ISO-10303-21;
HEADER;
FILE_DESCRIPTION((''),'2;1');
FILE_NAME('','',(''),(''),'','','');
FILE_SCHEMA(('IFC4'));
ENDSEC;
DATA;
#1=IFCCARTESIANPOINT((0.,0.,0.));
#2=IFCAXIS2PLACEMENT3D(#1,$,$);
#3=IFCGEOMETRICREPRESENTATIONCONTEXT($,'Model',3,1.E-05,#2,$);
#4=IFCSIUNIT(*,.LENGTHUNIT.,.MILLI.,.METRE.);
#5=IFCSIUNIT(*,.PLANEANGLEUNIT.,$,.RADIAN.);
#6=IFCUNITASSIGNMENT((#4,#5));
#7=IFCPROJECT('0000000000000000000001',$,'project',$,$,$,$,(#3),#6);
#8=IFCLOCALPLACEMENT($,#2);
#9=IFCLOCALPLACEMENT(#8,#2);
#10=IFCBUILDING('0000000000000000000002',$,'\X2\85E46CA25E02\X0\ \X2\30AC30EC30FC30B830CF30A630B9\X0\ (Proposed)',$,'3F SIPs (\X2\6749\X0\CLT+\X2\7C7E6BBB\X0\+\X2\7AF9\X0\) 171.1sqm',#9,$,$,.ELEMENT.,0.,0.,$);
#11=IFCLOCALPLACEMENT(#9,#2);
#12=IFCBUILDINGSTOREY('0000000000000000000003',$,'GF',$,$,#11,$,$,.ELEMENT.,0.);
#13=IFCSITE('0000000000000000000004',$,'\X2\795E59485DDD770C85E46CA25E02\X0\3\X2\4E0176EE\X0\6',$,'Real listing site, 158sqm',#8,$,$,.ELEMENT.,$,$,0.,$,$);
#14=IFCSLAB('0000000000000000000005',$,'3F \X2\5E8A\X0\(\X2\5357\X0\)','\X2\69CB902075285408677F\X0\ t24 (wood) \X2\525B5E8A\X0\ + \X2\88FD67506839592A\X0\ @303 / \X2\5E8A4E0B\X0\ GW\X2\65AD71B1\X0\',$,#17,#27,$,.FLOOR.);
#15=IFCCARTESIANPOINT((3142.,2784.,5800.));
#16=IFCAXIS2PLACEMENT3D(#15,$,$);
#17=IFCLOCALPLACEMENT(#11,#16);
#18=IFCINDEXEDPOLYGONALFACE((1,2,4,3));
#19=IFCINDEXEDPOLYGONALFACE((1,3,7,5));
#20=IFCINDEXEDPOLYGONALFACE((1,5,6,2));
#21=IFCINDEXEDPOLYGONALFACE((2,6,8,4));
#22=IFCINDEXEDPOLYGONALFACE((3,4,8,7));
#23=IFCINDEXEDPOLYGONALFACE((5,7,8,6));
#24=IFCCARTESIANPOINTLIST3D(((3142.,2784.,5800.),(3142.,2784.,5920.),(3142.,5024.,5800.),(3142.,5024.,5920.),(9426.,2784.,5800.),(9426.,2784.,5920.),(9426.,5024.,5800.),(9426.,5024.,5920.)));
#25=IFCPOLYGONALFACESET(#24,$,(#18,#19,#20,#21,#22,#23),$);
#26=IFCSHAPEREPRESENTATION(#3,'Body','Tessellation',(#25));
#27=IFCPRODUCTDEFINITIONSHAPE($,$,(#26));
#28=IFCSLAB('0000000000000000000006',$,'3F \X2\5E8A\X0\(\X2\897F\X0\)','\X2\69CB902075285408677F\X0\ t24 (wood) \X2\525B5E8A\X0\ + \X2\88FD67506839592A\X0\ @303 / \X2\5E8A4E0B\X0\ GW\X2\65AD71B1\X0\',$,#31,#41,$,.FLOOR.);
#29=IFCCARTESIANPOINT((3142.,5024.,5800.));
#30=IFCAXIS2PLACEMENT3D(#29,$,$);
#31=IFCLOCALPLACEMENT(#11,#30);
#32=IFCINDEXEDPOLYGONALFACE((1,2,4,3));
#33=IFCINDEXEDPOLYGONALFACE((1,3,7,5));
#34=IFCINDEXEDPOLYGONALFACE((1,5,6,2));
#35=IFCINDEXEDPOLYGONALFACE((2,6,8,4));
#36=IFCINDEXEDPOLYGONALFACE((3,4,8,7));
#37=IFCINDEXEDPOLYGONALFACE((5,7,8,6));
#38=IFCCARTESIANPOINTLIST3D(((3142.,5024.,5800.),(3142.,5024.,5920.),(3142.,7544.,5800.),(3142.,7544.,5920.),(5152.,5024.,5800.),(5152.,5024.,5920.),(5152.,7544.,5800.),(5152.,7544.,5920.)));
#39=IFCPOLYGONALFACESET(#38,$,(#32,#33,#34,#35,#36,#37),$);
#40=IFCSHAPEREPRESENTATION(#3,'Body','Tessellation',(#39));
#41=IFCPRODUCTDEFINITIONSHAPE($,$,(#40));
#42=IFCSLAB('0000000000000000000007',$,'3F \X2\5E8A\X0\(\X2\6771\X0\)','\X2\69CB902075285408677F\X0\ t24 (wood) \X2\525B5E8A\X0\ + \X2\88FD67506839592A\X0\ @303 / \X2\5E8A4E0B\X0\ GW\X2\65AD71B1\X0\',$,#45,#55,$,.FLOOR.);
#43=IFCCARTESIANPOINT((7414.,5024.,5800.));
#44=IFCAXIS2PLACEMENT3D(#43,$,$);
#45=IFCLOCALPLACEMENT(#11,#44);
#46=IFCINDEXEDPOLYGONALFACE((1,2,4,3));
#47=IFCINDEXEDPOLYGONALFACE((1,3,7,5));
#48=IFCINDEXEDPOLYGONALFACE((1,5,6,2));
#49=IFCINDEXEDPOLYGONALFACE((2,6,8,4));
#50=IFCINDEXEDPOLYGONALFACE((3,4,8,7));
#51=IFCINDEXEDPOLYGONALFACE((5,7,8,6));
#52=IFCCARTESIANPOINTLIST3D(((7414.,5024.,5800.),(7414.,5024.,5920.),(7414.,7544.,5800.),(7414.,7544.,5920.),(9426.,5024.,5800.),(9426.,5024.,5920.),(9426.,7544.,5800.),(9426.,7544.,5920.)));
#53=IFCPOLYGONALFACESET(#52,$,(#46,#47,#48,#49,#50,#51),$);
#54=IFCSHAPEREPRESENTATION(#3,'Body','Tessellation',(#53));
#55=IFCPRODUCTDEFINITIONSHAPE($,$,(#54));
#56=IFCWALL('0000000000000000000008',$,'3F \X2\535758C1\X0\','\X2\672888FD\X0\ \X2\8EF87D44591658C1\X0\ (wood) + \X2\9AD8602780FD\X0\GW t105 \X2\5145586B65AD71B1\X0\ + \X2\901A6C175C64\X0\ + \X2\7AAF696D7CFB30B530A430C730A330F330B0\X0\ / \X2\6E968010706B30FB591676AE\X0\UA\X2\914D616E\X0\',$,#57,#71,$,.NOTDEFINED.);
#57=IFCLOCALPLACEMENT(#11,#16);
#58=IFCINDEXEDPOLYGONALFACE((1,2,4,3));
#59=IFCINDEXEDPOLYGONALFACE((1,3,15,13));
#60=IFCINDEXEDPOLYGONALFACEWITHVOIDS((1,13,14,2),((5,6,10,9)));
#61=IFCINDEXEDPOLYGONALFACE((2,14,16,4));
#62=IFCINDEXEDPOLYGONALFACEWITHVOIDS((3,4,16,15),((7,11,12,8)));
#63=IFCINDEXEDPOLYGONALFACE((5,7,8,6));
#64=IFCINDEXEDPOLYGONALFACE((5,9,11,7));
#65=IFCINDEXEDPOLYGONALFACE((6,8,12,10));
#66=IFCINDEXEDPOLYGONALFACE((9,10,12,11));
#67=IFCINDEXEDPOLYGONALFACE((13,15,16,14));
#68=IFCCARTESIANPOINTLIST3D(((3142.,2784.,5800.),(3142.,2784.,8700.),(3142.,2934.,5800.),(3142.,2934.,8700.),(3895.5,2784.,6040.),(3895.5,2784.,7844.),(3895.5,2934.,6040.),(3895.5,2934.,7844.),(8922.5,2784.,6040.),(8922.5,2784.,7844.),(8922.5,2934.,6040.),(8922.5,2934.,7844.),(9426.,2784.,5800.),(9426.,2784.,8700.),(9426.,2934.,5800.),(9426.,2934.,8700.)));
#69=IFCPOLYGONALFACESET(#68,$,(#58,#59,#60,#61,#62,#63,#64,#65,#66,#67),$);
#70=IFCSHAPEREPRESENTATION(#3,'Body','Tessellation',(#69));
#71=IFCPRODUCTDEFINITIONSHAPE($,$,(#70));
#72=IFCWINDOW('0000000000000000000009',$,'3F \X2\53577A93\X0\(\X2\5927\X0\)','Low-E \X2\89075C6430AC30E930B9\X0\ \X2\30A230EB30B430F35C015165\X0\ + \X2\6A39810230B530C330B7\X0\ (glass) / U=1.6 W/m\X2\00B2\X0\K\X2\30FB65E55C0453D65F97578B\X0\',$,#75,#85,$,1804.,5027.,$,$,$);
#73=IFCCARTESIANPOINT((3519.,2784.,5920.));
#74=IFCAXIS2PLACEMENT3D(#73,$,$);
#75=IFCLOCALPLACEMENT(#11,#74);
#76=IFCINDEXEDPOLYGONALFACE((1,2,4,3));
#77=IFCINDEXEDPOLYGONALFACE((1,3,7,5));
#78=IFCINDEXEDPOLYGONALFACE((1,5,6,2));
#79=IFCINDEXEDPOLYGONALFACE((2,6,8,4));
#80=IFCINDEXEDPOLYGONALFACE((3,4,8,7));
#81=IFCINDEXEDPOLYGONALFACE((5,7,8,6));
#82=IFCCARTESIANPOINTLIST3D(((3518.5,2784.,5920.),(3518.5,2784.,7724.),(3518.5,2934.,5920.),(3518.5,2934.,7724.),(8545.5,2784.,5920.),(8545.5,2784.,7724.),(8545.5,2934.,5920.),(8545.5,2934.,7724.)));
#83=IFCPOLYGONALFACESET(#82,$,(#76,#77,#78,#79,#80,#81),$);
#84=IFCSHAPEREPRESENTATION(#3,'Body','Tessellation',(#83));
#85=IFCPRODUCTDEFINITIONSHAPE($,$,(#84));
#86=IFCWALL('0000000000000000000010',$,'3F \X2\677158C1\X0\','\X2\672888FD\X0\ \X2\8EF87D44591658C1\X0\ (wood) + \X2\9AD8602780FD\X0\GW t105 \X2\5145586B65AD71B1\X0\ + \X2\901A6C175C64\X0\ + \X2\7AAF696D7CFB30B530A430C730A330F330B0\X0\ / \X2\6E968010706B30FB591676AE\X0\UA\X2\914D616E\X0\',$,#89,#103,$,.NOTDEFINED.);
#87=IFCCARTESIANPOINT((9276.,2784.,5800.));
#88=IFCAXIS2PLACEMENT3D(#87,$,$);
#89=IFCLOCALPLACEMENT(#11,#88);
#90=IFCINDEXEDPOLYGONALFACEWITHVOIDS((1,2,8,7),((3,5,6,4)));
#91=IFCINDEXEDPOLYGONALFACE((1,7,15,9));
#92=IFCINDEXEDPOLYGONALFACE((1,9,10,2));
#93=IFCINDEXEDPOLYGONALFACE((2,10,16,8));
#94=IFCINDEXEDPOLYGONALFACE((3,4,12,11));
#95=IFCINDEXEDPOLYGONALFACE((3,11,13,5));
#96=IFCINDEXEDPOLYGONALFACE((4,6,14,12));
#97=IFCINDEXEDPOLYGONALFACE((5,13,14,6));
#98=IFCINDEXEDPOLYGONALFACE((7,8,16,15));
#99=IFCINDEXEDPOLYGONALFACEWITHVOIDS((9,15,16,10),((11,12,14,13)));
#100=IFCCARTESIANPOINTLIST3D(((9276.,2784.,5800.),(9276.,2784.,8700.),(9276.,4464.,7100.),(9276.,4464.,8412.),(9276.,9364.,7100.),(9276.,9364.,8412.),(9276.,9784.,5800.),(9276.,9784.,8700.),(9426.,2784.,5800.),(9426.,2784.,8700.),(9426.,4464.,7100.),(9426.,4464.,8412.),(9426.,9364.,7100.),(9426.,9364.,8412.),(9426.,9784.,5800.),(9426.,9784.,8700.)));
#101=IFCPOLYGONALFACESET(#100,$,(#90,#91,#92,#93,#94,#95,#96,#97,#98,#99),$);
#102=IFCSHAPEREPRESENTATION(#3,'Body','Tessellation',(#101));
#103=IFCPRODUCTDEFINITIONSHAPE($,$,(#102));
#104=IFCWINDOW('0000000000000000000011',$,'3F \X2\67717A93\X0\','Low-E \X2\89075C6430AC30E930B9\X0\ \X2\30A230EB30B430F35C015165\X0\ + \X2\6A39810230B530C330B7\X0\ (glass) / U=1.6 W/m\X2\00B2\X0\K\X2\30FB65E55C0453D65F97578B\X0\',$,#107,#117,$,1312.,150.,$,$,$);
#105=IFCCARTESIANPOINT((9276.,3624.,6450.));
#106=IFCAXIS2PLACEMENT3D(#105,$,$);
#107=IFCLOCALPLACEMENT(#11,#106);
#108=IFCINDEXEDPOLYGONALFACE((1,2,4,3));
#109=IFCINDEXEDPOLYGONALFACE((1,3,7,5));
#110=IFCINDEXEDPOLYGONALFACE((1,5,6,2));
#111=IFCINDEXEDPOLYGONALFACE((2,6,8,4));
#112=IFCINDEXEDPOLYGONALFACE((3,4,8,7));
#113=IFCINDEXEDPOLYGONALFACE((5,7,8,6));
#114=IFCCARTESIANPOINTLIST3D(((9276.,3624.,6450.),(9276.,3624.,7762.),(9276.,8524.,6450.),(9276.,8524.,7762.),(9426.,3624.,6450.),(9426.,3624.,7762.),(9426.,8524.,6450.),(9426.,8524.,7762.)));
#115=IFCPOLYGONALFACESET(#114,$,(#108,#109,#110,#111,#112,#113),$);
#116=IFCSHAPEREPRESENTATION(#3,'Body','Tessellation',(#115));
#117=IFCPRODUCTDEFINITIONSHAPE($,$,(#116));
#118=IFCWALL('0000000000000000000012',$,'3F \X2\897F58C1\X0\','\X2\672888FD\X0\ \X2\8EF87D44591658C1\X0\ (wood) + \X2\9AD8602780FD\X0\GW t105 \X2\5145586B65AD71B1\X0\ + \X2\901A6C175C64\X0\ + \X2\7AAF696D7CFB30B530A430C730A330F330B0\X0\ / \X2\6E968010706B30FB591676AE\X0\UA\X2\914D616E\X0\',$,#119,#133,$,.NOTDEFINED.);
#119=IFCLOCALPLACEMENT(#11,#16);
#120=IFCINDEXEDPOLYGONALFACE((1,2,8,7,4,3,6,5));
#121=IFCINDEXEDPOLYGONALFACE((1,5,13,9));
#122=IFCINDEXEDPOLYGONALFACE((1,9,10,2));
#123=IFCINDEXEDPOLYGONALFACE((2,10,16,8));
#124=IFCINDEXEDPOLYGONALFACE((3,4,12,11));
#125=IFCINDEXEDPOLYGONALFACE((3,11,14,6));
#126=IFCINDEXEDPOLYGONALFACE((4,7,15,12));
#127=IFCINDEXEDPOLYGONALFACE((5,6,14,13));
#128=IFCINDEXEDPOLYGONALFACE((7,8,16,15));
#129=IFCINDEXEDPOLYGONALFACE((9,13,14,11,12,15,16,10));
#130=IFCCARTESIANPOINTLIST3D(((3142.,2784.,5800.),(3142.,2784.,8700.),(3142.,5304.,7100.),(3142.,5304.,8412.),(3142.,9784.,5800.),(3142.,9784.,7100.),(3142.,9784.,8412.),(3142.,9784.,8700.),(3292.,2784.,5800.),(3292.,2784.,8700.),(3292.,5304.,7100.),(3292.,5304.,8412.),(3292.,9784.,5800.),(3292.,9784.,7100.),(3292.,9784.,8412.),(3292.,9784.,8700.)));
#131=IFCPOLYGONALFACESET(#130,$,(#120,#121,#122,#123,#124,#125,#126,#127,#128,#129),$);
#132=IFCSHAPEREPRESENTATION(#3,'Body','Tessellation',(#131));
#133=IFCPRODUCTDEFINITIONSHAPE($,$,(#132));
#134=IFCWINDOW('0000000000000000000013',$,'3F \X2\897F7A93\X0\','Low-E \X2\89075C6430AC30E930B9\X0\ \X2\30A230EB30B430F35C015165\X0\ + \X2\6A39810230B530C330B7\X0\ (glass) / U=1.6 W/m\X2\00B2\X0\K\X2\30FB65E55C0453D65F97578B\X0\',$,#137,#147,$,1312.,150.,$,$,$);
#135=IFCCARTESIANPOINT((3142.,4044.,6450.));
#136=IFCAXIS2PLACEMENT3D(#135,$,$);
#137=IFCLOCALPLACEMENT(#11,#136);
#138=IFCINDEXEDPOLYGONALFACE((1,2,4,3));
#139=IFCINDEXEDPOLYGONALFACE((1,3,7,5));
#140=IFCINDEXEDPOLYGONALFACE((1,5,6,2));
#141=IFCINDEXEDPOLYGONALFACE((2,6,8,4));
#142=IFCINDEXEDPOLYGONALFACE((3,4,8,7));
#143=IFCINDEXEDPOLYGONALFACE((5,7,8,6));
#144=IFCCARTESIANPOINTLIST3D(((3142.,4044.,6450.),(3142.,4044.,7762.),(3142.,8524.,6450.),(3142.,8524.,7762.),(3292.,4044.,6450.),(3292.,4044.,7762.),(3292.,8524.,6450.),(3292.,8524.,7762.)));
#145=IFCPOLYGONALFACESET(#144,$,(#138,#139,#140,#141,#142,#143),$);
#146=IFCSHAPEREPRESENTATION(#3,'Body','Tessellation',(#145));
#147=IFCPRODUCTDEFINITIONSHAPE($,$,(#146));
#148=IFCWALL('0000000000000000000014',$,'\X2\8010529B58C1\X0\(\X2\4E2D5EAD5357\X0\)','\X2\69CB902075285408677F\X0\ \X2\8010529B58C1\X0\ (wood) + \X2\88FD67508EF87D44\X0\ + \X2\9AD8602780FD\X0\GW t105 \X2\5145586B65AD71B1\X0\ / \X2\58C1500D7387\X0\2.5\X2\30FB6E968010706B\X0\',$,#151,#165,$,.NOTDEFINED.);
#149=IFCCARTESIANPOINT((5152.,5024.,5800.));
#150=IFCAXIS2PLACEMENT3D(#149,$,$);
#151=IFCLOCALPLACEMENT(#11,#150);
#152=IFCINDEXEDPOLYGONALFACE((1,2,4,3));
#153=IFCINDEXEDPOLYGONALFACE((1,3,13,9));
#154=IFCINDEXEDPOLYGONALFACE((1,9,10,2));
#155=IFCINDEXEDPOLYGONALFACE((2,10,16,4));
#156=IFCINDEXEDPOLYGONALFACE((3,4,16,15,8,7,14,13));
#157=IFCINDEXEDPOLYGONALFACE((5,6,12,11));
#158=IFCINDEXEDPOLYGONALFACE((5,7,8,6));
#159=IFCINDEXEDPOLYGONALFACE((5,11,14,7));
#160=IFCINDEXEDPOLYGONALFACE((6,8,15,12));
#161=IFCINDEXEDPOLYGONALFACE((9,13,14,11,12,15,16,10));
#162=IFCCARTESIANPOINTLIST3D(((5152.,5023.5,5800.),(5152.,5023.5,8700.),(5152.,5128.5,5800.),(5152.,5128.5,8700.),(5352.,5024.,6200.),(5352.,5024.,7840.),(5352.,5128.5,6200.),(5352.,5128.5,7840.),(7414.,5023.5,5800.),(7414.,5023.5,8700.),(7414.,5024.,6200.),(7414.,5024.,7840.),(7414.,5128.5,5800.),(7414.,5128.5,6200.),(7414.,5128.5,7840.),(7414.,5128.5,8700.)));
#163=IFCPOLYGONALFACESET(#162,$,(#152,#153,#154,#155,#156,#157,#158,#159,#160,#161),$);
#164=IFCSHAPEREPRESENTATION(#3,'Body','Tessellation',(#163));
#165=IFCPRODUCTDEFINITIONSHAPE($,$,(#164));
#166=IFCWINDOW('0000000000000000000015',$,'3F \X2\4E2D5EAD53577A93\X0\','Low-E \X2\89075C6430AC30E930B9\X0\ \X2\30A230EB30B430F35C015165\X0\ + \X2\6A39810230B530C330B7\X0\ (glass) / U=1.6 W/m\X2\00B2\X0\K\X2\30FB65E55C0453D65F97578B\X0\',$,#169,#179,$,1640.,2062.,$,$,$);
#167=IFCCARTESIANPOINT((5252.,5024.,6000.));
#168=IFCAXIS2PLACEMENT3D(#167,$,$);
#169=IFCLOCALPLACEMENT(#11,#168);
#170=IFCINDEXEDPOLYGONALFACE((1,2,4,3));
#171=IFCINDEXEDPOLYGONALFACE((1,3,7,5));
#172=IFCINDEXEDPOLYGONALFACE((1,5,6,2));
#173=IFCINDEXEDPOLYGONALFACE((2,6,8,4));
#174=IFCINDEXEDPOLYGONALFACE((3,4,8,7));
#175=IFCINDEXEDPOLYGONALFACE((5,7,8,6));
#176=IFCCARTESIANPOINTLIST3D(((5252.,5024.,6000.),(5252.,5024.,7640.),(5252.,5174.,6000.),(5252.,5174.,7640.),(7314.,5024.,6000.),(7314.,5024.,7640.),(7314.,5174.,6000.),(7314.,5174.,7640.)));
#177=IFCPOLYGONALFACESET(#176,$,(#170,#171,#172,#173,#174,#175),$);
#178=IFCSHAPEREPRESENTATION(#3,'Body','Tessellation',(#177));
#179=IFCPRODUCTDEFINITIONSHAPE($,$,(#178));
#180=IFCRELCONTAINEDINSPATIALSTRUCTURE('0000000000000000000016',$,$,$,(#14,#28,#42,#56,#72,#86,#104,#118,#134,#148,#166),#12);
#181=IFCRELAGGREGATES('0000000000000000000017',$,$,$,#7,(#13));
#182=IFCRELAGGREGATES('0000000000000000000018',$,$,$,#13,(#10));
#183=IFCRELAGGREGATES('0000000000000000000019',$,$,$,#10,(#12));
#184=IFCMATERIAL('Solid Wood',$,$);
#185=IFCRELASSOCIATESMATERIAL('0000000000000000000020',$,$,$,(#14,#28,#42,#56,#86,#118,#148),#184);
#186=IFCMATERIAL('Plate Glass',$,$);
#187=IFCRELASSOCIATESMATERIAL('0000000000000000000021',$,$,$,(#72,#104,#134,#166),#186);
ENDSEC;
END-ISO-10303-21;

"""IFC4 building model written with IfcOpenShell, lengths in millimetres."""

from ifc_helpers import new_model, si_unit, frame, frame_2d, origin, place, context, project, spatial, rectangle, extrude, material, element, fill, save


model = new_model("IFC4")

# Units and contexts
model_context = context("Model", 3, precision=1e-05, world=origin())
ifc_project = project(units=[si_unit("LENGTHUNIT", "METRE", prefix="MILLI"), si_unit("PLANEANGLEUNIT", "RADIAN")], contexts=[model_context])

# Site, building, storey
site_placement = place(None, origin())
site = spatial("IfcSite", under=ifc_project, at=site_placement, Name="神奈川県藤沢市3丁目6", ObjectType="Real listing site, 158sqm", CompositionType="ELEMENT", RefElevation=0.0)
building_placement = place(site_placement, origin())
building = spatial("IfcBuilding", under=site, at=building_placement, Name="藤沢市 ガレージハウス (Proposed)", ObjectType="3F SIPs (杉CLT+籾殻+竹) 171.1sqm", CompositionType="ELEMENT", ElevationOfRefHeight=0.0, ElevationOfTerrain=0.0)
storey_placement = place(building_placement, origin())
storey = spatial("IfcBuildingStorey", under=building, at=storey_placement, Name="GF", CompositionType="ELEMENT", Elevation=0.0)

# Slabs
ifc_material_1 = material(Name="Solid Wood")
slab_1_placement = place(storey_placement, frame((3142.0, 2784.0, 5800.0)))
element("IfcSlab", 1, at=slab_1_placement, inside=storey, material=ifc_material_1, Name="3F 床(南)", Description="構造用合板 t24 (wood) 剛床 + 製材根太 @303 / 床下 GW断熱", PredefinedType="FLOOR", context=model_context, shape_type="SweptSolid", body=[
    extrude(rectangle(XDim=6284.0, YDim=2240.0, at=frame_2d((3142.0, 1120.0))), frame((3142.0, 2784.0, 5800.0)), (0.0, 0.0, 1.0), 120.0),
])
slab_2_placement = place(storey_placement, frame((3142.0, 5024.0, 5800.0)))
element("IfcSlab", 2, at=slab_2_placement, inside=storey, material=ifc_material_1, Name="3F 床(西)", Description="構造用合板 t24 (wood) 剛床 + 製材根太 @303 / 床下 GW断熱", PredefinedType="FLOOR", context=model_context, shape_type="SweptSolid", body=[
    extrude(rectangle(XDim=2010.0, YDim=2520.0, at=frame_2d((1005.0, 1260.0))), frame((3142.0, 5024.0, 5800.0)), (0.0, 0.0, 1.0), 120.0),
])
slab_3_placement = place(storey_placement, frame((7414.0, 5024.0, 5800.0)))
element("IfcSlab", 3, at=slab_3_placement, inside=storey, material=ifc_material_1, Name="3F 床(東)", Description="構造用合板 t24 (wood) 剛床 + 製材根太 @303 / 床下 GW断熱", PredefinedType="FLOOR", context=model_context, shape_type="SweptSolid", body=[
    extrude(rectangle(XDim=2012.0, YDim=2520.0, at=frame_2d((1006.0, 1260.0))), frame((7414.0, 5024.0, 5800.0)), (0.0, 0.0, 1.0), 120.0),
])

# Walls, openings, windows
wall_1_placement = place(storey_placement, frame((3142.0, 2784.0, 5800.0)))
wall_1 = element("IfcWall", 4, at=wall_1_placement, inside=storey, material=ifc_material_1, Name="3F 南壁", Description="木製 軸組外壁 (wood) + 高性能GW t105 充填断熱 + 通気層 + 窯業系サイディング / 準耐火・外皮UA配慮", PredefinedType="NOTDEFINED", context=model_context, shape_type="SweptSolid", body=[
    extrude(rectangle(XDim=6284.0, YDim=150.0, at=frame_2d((3142.0, 75.0))), frame((3142.0, 2784.0, 5800.0)), (0.0, 0.0, 1.0), 2900.0),
])
opening_1_placement = place(storey_placement, frame((3519.0, 2784.0, 5920.0)))
opening_1 = element("IfcOpeningElement", 5, at=opening_1_placement, cuts=wall_1, PredefinedType="NOTDEFINED", context=model_context, shape_type="SweptSolid", body=[
    extrude(rectangle(XDim=5027.0, YDim=150.0, at=frame_2d((2513.0, 75.0))), frame((3519.0, 2784.0, 5920.0)), (0.0, 0.0, 1.0), 1804.0),
])
ifc_material_2 = material(Name="Plate Glass")
window_1_placement = place(storey_placement, frame((3519.0, 2784.0, 5920.0)))
window_1 = element("IfcWindow", 6, at=window_1_placement, inside=storey, material=ifc_material_2, Name="3F 南窓(大)", Description="Low-E 複層ガラス アルゴン封入 + 樹脂サッシ (glass) / U=1.6 W/m²K・日射取得型", OverallHeight=1804.0, OverallWidth=5027.0, context=model_context, shape_type="SweptSolid", body=[
    extrude(rectangle(XDim=5027.0, YDim=150.0, at=frame_2d((2513.0, 75.0))), frame((3519.0, 2784.0, 5920.0)), (0.0, 0.0, 1.0), 1804.0),
])
fill(opening_1, window_1)
wall_2_placement = place(storey_placement, frame((9276.0, 2784.0, 5800.0)))
wall_2 = element("IfcWall", 7, at=wall_2_placement, inside=storey, material=ifc_material_1, Name="3F 東壁", Description="木製 軸組外壁 (wood) + 高性能GW t105 充填断熱 + 通気層 + 窯業系サイディング / 準耐火・外皮UA配慮", PredefinedType="NOTDEFINED", context=model_context, shape_type="SweptSolid", body=[
    extrude(rectangle(XDim=150.0, YDim=7000.0, at=frame_2d((75.0, 3500.0))), frame((9276.0, 2784.0, 5800.0)), (0.0, 0.0, 1.0), 2900.0),
])
opening_2_placement = place(storey_placement, frame((9276.0, 3624.0, 6450.0)))
opening_2 = element("IfcOpeningElement", 8, at=opening_2_placement, cuts=wall_2, PredefinedType="NOTDEFINED", context=model_context, shape_type="SweptSolid", body=[
    extrude(rectangle(XDim=150.0, YDim=4900.0, at=frame_2d((75.0, 2450.0))), frame((9276.0, 3624.0, 6450.0)), (0.0, 0.0, 1.0), 1312.0),
])
window_2_placement = place(storey_placement, frame((9276.0, 3624.0, 6450.0)))
window_2 = element("IfcWindow", 9, at=window_2_placement, inside=storey, material=ifc_material_2, Name="3F 東窓", Description="Low-E 複層ガラス アルゴン封入 + 樹脂サッシ (glass) / U=1.6 W/m²K・日射取得型", OverallHeight=1312.0, OverallWidth=150.0, context=model_context, shape_type="SweptSolid", body=[
    extrude(rectangle(XDim=150.0, YDim=4900.0, at=frame_2d((75.0, 2450.0))), frame((9276.0, 3624.0, 6450.0)), (0.0, 0.0, 1.0), 1312.0),
])
fill(opening_2, window_2)
wall_3_placement = place(storey_placement, frame((3142.0, 2784.0, 5800.0)))
wall_3 = element("IfcWall", 10, at=wall_3_placement, inside=storey, material=ifc_material_1, Name="3F 西壁", Description="木製 軸組外壁 (wood) + 高性能GW t105 充填断熱 + 通気層 + 窯業系サイディング / 準耐火・外皮UA配慮", PredefinedType="NOTDEFINED", context=model_context, shape_type="SweptSolid", body=[
    extrude(rectangle(XDim=150.0, YDim=7000.0, at=frame_2d((75.0, 3500.0))), frame((3142.0, 2784.0, 5800.0)), (0.0, 0.0, 1.0), 2900.0),
])
opening_3_placement = place(storey_placement, frame((3142.0, 4044.0, 6450.0)))
opening_3 = element("IfcOpeningElement", 11, at=opening_3_placement, cuts=wall_3, PredefinedType="NOTDEFINED", context=model_context, shape_type="SweptSolid", body=[
    extrude(rectangle(XDim=150.0, YDim=4480.0, at=frame_2d((75.0, 2240.0))), frame((3142.0, 4044.0, 6450.0)), (0.0, 0.0, 1.0), 1312.0),
])
window_3_placement = place(storey_placement, frame((3142.0, 4044.0, 6450.0)))
window_3 = element("IfcWindow", 12, at=window_3_placement, inside=storey, material=ifc_material_2, Name="3F 西窓", Description="Low-E 複層ガラス アルゴン封入 + 樹脂サッシ (glass) / U=1.6 W/m²K・日射取得型", OverallHeight=1312.0, OverallWidth=150.0, context=model_context, shape_type="SweptSolid", body=[
    extrude(rectangle(XDim=150.0, YDim=4480.0, at=frame_2d((75.0, 2240.0))), frame((3142.0, 4044.0, 6450.0)), (0.0, 0.0, 1.0), 1312.0),
])
fill(opening_3, window_3)
wall_4_placement = place(storey_placement, frame((5152.0, 5024.0, 5800.0)))
wall_4 = element("IfcWall", 13, at=wall_4_placement, inside=storey, material=ifc_material_1, Name="耐力壁(中庭南)", Description="構造用合板 耐力壁 (wood) + 製材軸組 + 高性能GW t105 充填断熱 / 壁倍率2.5・準耐火", PredefinedType="NOTDEFINED", context=model_context, shape_type="SweptSolid", body=[
    extrude(rectangle(XDim=2262.0, YDim=105.0, at=frame_2d((1131.0, 52.0))), frame((5152.0, 5024.0, 5800.0)), (0.0, 0.0, 1.0), 2900.0),
])
opening_4_placement = place(storey_placement, frame((5252.0, 5024.0, 6000.0)))
opening_4 = element("IfcOpeningElement", 14, at=opening_4_placement, cuts=wall_4, PredefinedType="NOTDEFINED", context=model_context, shape_type="SweptSolid", body=[
    extrude(rectangle(XDim=2062.0, YDim=150.0, at=frame_2d((1031.0, 75.0))), frame((5252.0, 5024.0, 6000.0)), (0.0, 0.0, 1.0), 1640.0),
])
window_4_placement = place(storey_placement, frame((5252.0, 5024.0, 6000.0)))
window_4 = element("IfcWindow", 15, at=window_4_placement, inside=storey, material=ifc_material_2, Name="3F 中庭南窓", Description="Low-E 複層ガラス アルゴン封入 + 樹脂サッシ (glass) / U=1.6 W/m²K・日射取得型", OverallHeight=1640.0, OverallWidth=2062.0, context=model_context, shape_type="SweptSolid", body=[
    extrude(rectangle(XDim=2062.0, YDim=150.0, at=frame_2d((1031.0, 75.0))), frame((5252.0, 5024.0, 6000.0)), (0.0, 0.0, 1.0), 1640.0),
])
fill(opening_4, window_4)

save(model, "model.ifc")
